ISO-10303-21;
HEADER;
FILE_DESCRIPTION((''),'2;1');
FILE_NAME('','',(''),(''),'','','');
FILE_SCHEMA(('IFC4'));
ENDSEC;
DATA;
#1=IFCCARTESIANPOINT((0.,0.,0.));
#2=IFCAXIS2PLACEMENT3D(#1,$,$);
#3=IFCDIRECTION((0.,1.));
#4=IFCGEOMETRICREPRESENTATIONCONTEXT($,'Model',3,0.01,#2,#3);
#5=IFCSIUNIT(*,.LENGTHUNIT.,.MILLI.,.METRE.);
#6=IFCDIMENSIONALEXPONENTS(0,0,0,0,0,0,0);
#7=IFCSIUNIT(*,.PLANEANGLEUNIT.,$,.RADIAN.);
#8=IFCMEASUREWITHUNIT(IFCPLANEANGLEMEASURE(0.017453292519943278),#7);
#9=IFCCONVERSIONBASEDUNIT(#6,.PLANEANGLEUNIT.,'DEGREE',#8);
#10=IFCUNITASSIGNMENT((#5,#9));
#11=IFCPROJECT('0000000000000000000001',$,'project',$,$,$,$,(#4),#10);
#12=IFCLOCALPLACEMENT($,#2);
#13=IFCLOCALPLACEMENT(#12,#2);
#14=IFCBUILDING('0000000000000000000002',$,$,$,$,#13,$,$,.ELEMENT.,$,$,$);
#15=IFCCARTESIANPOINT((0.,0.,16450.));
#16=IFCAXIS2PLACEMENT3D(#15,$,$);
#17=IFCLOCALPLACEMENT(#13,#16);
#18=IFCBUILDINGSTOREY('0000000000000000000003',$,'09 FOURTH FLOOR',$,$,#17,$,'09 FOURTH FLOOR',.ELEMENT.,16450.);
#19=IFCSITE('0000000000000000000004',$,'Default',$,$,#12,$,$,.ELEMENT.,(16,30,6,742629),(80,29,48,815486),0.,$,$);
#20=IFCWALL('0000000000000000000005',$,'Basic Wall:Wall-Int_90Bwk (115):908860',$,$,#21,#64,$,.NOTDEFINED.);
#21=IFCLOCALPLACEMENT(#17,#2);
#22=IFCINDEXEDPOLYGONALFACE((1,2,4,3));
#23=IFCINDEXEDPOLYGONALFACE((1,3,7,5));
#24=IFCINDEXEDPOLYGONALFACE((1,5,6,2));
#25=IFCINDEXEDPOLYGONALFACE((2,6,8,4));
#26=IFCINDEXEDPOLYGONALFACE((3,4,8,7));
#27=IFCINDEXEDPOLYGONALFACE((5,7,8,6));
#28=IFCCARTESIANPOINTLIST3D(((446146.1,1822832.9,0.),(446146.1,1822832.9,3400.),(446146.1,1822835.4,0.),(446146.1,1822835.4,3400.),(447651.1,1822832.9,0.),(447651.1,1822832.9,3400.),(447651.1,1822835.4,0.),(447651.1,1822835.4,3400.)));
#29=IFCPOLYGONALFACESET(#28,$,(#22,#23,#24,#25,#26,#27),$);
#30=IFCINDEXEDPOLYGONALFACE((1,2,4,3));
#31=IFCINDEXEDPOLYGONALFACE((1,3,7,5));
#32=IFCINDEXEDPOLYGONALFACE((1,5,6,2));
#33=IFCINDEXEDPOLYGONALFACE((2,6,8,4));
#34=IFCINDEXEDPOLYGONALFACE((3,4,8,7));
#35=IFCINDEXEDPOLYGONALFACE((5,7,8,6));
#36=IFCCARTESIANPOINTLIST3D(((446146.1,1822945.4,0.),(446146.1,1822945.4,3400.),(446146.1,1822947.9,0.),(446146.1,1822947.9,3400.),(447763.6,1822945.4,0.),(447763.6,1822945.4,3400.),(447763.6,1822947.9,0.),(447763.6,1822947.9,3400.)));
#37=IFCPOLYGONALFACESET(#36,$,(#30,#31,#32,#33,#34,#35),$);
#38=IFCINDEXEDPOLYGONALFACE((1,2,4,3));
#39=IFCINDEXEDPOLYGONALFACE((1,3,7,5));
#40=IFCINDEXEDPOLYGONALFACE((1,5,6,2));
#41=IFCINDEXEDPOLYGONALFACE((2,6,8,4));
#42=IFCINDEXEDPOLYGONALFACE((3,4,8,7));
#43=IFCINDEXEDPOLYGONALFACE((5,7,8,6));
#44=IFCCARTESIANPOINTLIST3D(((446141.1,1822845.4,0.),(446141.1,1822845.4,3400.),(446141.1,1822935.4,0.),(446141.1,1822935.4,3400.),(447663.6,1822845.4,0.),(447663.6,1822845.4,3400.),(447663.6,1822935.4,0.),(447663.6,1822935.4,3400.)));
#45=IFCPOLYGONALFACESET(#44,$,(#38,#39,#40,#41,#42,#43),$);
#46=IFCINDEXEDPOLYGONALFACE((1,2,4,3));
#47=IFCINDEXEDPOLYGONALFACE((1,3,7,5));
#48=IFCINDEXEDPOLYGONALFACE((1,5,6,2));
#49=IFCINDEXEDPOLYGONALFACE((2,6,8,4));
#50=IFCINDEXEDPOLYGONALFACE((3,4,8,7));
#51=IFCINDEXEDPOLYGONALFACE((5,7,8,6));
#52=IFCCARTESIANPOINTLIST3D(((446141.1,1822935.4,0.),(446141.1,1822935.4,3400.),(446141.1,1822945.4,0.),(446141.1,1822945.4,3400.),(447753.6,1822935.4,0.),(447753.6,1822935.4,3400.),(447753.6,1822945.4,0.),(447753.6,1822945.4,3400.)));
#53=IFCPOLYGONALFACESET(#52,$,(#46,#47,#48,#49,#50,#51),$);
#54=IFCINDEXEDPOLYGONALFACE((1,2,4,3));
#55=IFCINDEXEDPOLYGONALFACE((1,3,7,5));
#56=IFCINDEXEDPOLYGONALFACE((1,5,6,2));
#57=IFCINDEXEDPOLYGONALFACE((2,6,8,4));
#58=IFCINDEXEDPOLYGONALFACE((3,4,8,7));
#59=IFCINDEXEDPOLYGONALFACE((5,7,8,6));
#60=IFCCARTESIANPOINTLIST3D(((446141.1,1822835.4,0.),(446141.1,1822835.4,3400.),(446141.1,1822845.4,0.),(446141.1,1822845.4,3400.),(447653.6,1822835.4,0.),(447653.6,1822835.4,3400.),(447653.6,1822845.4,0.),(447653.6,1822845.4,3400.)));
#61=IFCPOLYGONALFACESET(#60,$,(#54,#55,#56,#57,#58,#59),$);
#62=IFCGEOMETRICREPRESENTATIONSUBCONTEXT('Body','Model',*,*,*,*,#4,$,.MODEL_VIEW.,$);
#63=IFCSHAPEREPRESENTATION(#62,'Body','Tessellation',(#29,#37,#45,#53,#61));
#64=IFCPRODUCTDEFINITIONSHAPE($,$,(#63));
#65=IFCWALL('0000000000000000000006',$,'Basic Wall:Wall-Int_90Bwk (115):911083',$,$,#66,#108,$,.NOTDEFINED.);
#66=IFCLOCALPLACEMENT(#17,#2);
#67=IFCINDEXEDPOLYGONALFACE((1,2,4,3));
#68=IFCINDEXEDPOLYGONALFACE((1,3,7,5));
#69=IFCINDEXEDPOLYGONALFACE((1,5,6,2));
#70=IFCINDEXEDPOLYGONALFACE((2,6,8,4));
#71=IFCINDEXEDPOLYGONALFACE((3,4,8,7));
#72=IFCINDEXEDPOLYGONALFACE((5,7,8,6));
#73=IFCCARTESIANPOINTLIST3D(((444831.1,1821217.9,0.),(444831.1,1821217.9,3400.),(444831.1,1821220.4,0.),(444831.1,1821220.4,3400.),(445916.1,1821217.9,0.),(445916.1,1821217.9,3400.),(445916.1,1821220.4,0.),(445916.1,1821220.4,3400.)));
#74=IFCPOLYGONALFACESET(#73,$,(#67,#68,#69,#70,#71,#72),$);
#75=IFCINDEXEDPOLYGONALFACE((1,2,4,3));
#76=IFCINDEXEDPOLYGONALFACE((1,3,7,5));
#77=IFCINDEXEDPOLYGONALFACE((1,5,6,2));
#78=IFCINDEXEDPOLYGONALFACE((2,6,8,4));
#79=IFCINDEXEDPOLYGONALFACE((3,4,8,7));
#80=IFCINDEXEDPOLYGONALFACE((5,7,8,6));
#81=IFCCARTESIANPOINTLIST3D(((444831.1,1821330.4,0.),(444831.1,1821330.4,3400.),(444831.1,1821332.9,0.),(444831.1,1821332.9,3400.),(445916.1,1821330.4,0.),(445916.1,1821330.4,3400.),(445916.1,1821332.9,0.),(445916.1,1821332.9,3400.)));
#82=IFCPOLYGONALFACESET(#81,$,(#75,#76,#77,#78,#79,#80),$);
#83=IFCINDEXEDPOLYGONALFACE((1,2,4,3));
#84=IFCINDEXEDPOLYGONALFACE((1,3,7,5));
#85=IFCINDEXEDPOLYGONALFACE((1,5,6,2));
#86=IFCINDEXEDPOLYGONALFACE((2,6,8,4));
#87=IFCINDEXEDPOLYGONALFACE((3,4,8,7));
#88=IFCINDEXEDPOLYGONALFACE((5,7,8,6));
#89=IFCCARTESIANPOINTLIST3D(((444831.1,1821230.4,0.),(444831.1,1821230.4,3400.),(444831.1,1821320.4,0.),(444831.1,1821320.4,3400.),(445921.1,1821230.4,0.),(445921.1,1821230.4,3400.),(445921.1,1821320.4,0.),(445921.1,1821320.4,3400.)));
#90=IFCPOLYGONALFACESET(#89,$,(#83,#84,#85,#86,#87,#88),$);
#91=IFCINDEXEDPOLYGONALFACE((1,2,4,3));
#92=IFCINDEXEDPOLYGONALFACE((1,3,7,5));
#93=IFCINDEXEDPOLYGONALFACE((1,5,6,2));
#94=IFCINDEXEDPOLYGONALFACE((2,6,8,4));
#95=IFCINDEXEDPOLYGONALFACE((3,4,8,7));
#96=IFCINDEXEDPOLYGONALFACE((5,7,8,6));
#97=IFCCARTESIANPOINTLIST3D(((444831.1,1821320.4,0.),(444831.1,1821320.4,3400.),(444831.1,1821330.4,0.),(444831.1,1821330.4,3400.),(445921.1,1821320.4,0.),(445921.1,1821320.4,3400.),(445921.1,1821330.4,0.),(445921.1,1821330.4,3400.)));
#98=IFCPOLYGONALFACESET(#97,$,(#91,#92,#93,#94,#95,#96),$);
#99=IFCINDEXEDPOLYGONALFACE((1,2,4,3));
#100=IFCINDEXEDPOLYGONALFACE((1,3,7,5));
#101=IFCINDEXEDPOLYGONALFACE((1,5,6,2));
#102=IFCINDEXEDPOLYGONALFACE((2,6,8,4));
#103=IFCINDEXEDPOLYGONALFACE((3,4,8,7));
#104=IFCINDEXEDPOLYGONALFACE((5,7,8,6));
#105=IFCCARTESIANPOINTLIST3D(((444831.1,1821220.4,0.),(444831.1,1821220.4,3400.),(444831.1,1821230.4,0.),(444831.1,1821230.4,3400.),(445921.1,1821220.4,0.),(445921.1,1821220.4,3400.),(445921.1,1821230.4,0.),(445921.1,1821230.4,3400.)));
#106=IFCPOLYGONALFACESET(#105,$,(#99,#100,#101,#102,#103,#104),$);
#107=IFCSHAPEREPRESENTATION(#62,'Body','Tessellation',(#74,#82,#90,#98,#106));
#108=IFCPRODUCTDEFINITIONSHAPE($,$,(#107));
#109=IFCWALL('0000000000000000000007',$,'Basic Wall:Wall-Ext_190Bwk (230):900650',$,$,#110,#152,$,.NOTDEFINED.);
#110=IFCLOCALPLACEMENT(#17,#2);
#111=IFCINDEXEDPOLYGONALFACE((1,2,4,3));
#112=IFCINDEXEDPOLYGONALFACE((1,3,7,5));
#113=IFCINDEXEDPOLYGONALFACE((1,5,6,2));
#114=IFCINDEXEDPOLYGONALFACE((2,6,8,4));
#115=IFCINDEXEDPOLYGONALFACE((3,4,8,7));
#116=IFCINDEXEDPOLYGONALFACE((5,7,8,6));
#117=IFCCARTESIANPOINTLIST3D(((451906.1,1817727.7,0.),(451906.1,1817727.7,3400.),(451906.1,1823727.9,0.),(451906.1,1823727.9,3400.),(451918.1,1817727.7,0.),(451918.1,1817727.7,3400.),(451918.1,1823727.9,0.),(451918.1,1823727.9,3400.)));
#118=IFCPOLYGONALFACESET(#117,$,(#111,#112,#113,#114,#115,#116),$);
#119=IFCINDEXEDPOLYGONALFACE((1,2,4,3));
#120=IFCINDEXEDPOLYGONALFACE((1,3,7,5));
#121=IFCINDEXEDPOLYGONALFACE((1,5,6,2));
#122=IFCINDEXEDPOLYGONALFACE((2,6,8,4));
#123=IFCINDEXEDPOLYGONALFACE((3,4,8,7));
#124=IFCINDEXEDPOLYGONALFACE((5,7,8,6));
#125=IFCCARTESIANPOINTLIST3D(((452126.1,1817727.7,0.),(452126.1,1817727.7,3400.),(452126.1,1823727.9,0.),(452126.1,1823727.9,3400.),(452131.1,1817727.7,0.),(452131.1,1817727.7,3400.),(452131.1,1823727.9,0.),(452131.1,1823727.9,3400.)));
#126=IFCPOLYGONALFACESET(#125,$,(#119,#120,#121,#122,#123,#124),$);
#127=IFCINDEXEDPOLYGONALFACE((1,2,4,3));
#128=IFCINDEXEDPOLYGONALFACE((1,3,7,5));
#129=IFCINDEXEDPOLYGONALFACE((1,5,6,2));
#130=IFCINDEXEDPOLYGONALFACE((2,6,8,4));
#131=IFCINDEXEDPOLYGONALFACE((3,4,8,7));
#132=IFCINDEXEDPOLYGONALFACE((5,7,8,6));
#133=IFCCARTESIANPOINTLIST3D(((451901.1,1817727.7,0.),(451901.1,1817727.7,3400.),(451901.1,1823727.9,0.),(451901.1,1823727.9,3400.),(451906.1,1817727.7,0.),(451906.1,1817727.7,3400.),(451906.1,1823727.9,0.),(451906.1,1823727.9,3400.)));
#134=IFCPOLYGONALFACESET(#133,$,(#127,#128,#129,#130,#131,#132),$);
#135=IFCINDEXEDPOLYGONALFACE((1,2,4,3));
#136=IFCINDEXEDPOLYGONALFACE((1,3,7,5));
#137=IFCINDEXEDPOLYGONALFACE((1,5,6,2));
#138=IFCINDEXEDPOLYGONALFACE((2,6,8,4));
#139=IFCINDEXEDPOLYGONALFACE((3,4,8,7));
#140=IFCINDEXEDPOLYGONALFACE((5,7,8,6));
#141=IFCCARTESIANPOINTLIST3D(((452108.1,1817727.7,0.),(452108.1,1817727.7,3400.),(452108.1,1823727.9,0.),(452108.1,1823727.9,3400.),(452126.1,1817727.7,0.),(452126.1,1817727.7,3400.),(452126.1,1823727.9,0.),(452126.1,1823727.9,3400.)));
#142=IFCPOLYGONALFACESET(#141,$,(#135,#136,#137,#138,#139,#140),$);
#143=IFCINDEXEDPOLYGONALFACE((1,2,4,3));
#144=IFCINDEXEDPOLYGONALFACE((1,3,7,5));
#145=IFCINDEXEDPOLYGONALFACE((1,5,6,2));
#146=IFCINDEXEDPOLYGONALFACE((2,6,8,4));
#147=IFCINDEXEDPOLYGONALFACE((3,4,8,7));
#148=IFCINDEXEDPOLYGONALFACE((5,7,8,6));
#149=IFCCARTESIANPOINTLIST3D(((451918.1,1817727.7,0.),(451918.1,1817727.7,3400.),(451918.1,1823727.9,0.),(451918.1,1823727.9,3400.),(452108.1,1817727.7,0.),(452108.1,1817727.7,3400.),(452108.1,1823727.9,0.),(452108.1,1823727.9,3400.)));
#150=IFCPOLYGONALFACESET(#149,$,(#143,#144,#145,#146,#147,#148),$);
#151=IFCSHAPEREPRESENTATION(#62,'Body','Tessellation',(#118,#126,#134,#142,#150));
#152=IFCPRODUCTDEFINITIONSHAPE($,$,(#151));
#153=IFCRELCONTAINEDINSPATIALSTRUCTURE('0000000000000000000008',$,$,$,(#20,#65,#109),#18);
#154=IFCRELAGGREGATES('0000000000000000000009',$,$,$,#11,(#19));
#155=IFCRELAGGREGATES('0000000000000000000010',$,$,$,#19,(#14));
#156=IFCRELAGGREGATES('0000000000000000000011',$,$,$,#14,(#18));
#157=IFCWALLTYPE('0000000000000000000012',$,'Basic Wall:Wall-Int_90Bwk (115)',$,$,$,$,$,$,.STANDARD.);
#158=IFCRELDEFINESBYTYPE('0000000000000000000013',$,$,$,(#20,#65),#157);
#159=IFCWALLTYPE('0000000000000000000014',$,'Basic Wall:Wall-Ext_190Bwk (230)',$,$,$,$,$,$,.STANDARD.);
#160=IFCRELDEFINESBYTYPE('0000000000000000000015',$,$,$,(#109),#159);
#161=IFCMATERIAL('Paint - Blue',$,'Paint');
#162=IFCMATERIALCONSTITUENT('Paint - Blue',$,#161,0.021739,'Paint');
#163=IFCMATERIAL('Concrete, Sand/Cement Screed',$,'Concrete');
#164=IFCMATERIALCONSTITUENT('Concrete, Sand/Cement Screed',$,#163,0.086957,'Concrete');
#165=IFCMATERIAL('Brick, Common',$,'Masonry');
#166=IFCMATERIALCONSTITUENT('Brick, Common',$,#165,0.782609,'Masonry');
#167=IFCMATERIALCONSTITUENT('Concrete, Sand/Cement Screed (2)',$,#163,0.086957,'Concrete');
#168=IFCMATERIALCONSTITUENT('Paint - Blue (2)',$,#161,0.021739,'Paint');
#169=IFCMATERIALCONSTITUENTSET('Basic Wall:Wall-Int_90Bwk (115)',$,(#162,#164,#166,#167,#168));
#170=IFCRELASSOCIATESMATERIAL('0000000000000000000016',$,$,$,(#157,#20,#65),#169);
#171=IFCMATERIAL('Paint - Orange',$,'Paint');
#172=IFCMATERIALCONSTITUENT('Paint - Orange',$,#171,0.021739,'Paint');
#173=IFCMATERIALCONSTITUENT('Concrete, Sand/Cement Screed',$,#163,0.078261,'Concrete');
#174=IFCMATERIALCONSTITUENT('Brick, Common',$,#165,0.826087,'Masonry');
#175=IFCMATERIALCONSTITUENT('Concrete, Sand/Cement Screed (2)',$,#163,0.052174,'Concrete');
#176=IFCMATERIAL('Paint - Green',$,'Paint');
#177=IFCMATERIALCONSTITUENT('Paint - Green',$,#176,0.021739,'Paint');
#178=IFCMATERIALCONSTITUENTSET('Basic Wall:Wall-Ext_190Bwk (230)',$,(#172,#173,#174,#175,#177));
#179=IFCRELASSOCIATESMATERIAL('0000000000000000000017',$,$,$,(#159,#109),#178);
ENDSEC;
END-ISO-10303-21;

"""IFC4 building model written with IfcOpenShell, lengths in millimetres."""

from ifc_helpers import new_model, entity, si_unit, converted_unit, direction, frame, origin, place, context, subcontext, project, spatial, indexed_curve, outline, extrude, material, constituent, constituent_set, type_object, element, save


model = new_model("IFC4")

# Units and contexts
model_context = context("Model", 3, precision=0.01, world=origin(), true_north=direction((0.0, 1.0)))
body_context = subcontext(model_context, "Body", "Model", "MODEL_VIEW")
ifc_project = project(units=[si_unit("LENGTHUNIT", "METRE", prefix="MILLI"), converted_unit("PLANEANGLEUNIT", "DEGREE", entity("IfcPlaneAngleMeasure", 0.017453292519943278), si_unit("PLANEANGLEUNIT", "RADIAN"), dimensions=[0, 0, 0, 0, 0, 0, 0])], contexts=[model_context])

# Site, building, storey
site_placement = place(None, origin())
site = spatial("IfcSite", under=ifc_project, at=site_placement, Name="Default", CompositionType="ELEMENT", RefLatitude=(16, 30, 6, 742629), RefLongitude=(80, 29, 48, 815486), RefElevation=0.0)
building_placement = place(site_placement, origin())
building = spatial("IfcBuilding", under=site, at=building_placement, CompositionType="ELEMENT")
storey_placement = place(building_placement, frame((0.0, 0.0, 16450.0)))
storey = spatial("IfcBuildingStorey", under=building, at=storey_placement, Name="09 FOURTH FLOOR", LongName="09 FOURTH FLOOR", CompositionType="ELEMENT", Elevation=16450.0)

# Shared definitions
ifc_material_1 = material(Name="Paint - Blue", Category="Paint")
ifc_constituent_1 = constituent(ifc_material_1, Name="Paint - Blue", Category="Paint", fraction=0.021739)
ifc_material_2 = material(Name="Concrete, Sand/Cement Screed", Category="Concrete")
ifc_constituent_2 = constituent(ifc_material_2, Name="Concrete, Sand/Cement Screed", Category="Concrete", fraction=0.086957)
ifc_material_3 = material(Name="Brick, Common", Category="Masonry")
ifc_constituent_3 = constituent(ifc_material_3, Name="Brick, Common", Category="Masonry", fraction=0.782609)
ifc_constituent_4 = constituent(ifc_material_2, Name="Concrete, Sand/Cement Screed (2)", Category="Concrete", fraction=0.086957)
ifc_constituent_5 = constituent(ifc_material_1, Name="Paint - Blue (2)", Category="Paint", fraction=0.021739)
ifc_constituent_set_1 = constituent_set(constituents=[ifc_constituent_1, ifc_constituent_2, ifc_constituent_3, ifc_constituent_4, ifc_constituent_5], Name="Basic Wall:Wall-Int_90Bwk (115)")
wall_type_1 = type_object("IfcWallType", Name="Basic Wall:Wall-Int_90Bwk (115)", PredefinedType="STANDARD", material=ifc_constituent_set_1)

# Wall
wall_1_placement = place(storey_placement, frame((447651.1, 1822890.4, 0.0), z_axis=(0.0, 0.0, 1.0), x_axis=(-1.0, 0.0, 0.0)))
element("IfcWall", 1, at=wall_1_placement, inside=storey, type_object=wall_type_1, material=ifc_constituent_set_1, Name="Basic Wall:Wall-Int_90Bwk (115):908860", PredefinedType="NOTDEFINED", context=body_context, shape_type="SweptSolid", body=[
    extrude(outline(indexed_curve([(-1.3, -752.5), (1.3, -752.5), (1.3, 752.5), (-1.3, 752.5), (-1.3, -752.5)], self_intersect=False)), frame((752.5, 56.3, 0.0), z_axis=(0.0, 0.0, 1.0), x_axis=(0.0, -1.0, 0.0)), (0.0, 0.0, 1.0), 3400.0),
    extrude(outline(indexed_curve([(-1.2, -808.7), (1.3, -808.7), (1.3, 808.8), (-1.2, 808.8), (-1.2, -808.7)], self_intersect=False)), frame((696.3, -56.3, 0.0), z_axis=(0.0, 0.0, 1.0), x_axis=(0.0, 1.0, 0.0)), (0.0, 0.0, 1.0), 3400.0),
    extrude(outline(indexed_curve([(-761.3, -45.0), (761.2, -45.0), (761.2, 45.0), (-761.3, 45.0), (-761.3, -45.0)], self_intersect=False)), frame((748.8, 0.0, 0.0)), (0.0, 0.0, 1.0), 3400.0),
    extrude(outline(indexed_curve([(-806.2, -5.0), (806.3, -5.0), (806.3, 5.0), (-806.2, 5.0), (-806.2, -5.0)], self_intersect=False)), frame((703.7, -50.0, 0.0)), (0.0, 0.0, 1.0), 3400.0),
    extrude(outline(indexed_curve([(-756.2, -5.0), (756.3, -5.0), (756.3, 5.0), (-756.2, 5.0), (-756.2, -5.0)], self_intersect=False)), frame((753.7, 50.0, 0.0)), (0.0, 0.0, 1.0), 3400.0),
])

# Wall
wall_2_placement = place(storey_placement, frame((445916.1, 1821275.4, 0.0), z_axis=(0.0, 0.0, 1.0), x_axis=(-1.0, 0.0, 0.0)))
element("IfcWall", 2, at=wall_2_placement, inside=storey, type_object=wall_type_1, material=ifc_constituent_set_1, Name="Basic Wall:Wall-Int_90Bwk (115):911083", PredefinedType="NOTDEFINED", context=body_context, shape_type="SweptSolid", body=[
    extrude(outline(indexed_curve([(-1.3, -542.5), (1.3, -542.5), (1.3, 542.5), (-1.3, 542.5), (-1.3, -542.5)], self_intersect=False)), frame((542.5, 56.3, 0.0), z_axis=(0.0, 0.0, 1.0), x_axis=(0.0, -1.0, 0.0)), (0.0, 0.0, 1.0), 3400.0),
    extrude(outline(indexed_curve([(-1.3, -542.5), (1.2, -542.5), (1.2, 542.5), (-1.3, 542.5), (-1.3, -542.5)], self_intersect=False)), frame((542.5, -56.2, 0.0), z_axis=(0.0, 0.0, 1.0), x_axis=(0.0, 1.0, 0.0)), (0.0, 0.0, 1.0), 3400.0),
    extrude(outline(indexed_curve([(-545.0, -45.0), (545.0, -45.0), (545.0, 45.0), (-545.0, 45.0), (-545.0, -45.0)], self_intersect=False)), frame((540.0, 0.0, 0.0)), (0.0, 0.0, 1.0), 3400.0),
    extrude(outline(indexed_curve([(-545.0, -5.0), (545.0, -5.0), (545.0, 5.0), (-545.0, 5.0), (-545.0, -5.0)], self_intersect=False)), frame((540.0, -50.0, 0.0)), (0.0, 0.0, 1.0), 3400.0),
    extrude(outline(indexed_curve([(-545.0, -5.0), (545.0, -5.0), (545.0, 5.0), (-545.0, 5.0), (-545.0, -5.0)], self_intersect=False)), frame((540.0, 50.0, 0.0)), (0.0, 0.0, 1.0), 3400.0),
])

# Shared definitions
ifc_material_4 = material(Name="Paint - Orange", Category="Paint")
ifc_constituent_6 = constituent(ifc_material_4, Name="Paint - Orange", Category="Paint", fraction=0.021739)
ifc_constituent_7 = constituent(ifc_material_2, Name="Concrete, Sand/Cement Screed", Category="Concrete", fraction=0.078261)
ifc_constituent_8 = constituent(ifc_material_3, Name="Brick, Common", Category="Masonry", fraction=0.826087)
ifc_constituent_9 = constituent(ifc_material_2, Name="Concrete, Sand/Cement Screed (2)", Category="Concrete", fraction=0.052174)
ifc_material_5 = material(Name="Paint - Green", Category="Paint")
ifc_constituent_10 = constituent(ifc_material_5, Name="Paint - Green", Category="Paint", fraction=0.021739)
ifc_constituent_set_2 = constituent_set(constituents=[ifc_constituent_6, ifc_constituent_7, ifc_constituent_8, ifc_constituent_9, ifc_constituent_10], Name="Basic Wall:Wall-Ext_190Bwk (230)")
wall_type_2 = type_object("IfcWallType", Name="Basic Wall:Wall-Ext_190Bwk (230)", PredefinedType="STANDARD", material=ifc_constituent_set_2)

# Wall
wall_3_placement = place(storey_placement, frame((452016.1, 1823727.9, 0.0), z_axis=(0.0, 0.0, 1.0), x_axis=(0.0, -1.0, 0.0)))
element("IfcWall", 3, at=wall_3_placement, inside=storey, type_object=wall_type_2, material=ifc_constituent_set_2, Name="Basic Wall:Wall-Ext_190Bwk (230):900650", PredefinedType="NOTDEFINED", context=body_context, shape_type="SweptSolid", body=[
    extrude(outline(indexed_curve([(-3000.1, -6.0), (3000.1, -6.0), (3000.1, 6.0), (-3000.1, 6.0), (-3000.1, -6.0)], self_intersect=False)), frame((3000.1, -104.0, 0.0)), (0.0, 0.0, 1.0), 3400.0),
    extrude(outline(indexed_curve([(-2.5, -3000.1), (2.5, -3000.1), (2.5, 3000.1), (-2.5, 3000.1), (-2.5, -3000.1)], self_intersect=False)), frame((3000.1, 112.5, 0.0), z_axis=(0.0, 0.0, 1.0), x_axis=(0.0, -1.0, 0.0)), (0.0, 0.0, 1.0), 3400.0),
    extrude(outline(indexed_curve([(-2.5, -3000.1), (2.5, -3000.1), (2.5, 3000.1), (-2.5, 3000.1), (-2.5, -3000.1)], self_intersect=False)), frame((3000.1, -112.5, 0.0), z_axis=(0.0, 0.0, 1.0), x_axis=(0.0, 1.0, 0.0)), (0.0, 0.0, 1.0), 3400.0),
    extrude(outline(indexed_curve([(-3000.1, -9.0), (3000.1, -9.0), (3000.1, 9.0), (-3000.1, 9.0), (-3000.1, -9.0)], self_intersect=False)), frame((3000.1, 101.0, 0.0)), (0.0, 0.0, 1.0), 3400.0),
    extrude(outline(indexed_curve([(-3000.1, -95.0), (3000.1, -95.0), (3000.1, 95.0), (-3000.1, 95.0), (-3000.1, -95.0)], self_intersect=False)), frame((3000.1, -3.0, 0.0)), (0.0, 0.0, 1.0), 3400.0),
])

save(model, "model.ifc")
